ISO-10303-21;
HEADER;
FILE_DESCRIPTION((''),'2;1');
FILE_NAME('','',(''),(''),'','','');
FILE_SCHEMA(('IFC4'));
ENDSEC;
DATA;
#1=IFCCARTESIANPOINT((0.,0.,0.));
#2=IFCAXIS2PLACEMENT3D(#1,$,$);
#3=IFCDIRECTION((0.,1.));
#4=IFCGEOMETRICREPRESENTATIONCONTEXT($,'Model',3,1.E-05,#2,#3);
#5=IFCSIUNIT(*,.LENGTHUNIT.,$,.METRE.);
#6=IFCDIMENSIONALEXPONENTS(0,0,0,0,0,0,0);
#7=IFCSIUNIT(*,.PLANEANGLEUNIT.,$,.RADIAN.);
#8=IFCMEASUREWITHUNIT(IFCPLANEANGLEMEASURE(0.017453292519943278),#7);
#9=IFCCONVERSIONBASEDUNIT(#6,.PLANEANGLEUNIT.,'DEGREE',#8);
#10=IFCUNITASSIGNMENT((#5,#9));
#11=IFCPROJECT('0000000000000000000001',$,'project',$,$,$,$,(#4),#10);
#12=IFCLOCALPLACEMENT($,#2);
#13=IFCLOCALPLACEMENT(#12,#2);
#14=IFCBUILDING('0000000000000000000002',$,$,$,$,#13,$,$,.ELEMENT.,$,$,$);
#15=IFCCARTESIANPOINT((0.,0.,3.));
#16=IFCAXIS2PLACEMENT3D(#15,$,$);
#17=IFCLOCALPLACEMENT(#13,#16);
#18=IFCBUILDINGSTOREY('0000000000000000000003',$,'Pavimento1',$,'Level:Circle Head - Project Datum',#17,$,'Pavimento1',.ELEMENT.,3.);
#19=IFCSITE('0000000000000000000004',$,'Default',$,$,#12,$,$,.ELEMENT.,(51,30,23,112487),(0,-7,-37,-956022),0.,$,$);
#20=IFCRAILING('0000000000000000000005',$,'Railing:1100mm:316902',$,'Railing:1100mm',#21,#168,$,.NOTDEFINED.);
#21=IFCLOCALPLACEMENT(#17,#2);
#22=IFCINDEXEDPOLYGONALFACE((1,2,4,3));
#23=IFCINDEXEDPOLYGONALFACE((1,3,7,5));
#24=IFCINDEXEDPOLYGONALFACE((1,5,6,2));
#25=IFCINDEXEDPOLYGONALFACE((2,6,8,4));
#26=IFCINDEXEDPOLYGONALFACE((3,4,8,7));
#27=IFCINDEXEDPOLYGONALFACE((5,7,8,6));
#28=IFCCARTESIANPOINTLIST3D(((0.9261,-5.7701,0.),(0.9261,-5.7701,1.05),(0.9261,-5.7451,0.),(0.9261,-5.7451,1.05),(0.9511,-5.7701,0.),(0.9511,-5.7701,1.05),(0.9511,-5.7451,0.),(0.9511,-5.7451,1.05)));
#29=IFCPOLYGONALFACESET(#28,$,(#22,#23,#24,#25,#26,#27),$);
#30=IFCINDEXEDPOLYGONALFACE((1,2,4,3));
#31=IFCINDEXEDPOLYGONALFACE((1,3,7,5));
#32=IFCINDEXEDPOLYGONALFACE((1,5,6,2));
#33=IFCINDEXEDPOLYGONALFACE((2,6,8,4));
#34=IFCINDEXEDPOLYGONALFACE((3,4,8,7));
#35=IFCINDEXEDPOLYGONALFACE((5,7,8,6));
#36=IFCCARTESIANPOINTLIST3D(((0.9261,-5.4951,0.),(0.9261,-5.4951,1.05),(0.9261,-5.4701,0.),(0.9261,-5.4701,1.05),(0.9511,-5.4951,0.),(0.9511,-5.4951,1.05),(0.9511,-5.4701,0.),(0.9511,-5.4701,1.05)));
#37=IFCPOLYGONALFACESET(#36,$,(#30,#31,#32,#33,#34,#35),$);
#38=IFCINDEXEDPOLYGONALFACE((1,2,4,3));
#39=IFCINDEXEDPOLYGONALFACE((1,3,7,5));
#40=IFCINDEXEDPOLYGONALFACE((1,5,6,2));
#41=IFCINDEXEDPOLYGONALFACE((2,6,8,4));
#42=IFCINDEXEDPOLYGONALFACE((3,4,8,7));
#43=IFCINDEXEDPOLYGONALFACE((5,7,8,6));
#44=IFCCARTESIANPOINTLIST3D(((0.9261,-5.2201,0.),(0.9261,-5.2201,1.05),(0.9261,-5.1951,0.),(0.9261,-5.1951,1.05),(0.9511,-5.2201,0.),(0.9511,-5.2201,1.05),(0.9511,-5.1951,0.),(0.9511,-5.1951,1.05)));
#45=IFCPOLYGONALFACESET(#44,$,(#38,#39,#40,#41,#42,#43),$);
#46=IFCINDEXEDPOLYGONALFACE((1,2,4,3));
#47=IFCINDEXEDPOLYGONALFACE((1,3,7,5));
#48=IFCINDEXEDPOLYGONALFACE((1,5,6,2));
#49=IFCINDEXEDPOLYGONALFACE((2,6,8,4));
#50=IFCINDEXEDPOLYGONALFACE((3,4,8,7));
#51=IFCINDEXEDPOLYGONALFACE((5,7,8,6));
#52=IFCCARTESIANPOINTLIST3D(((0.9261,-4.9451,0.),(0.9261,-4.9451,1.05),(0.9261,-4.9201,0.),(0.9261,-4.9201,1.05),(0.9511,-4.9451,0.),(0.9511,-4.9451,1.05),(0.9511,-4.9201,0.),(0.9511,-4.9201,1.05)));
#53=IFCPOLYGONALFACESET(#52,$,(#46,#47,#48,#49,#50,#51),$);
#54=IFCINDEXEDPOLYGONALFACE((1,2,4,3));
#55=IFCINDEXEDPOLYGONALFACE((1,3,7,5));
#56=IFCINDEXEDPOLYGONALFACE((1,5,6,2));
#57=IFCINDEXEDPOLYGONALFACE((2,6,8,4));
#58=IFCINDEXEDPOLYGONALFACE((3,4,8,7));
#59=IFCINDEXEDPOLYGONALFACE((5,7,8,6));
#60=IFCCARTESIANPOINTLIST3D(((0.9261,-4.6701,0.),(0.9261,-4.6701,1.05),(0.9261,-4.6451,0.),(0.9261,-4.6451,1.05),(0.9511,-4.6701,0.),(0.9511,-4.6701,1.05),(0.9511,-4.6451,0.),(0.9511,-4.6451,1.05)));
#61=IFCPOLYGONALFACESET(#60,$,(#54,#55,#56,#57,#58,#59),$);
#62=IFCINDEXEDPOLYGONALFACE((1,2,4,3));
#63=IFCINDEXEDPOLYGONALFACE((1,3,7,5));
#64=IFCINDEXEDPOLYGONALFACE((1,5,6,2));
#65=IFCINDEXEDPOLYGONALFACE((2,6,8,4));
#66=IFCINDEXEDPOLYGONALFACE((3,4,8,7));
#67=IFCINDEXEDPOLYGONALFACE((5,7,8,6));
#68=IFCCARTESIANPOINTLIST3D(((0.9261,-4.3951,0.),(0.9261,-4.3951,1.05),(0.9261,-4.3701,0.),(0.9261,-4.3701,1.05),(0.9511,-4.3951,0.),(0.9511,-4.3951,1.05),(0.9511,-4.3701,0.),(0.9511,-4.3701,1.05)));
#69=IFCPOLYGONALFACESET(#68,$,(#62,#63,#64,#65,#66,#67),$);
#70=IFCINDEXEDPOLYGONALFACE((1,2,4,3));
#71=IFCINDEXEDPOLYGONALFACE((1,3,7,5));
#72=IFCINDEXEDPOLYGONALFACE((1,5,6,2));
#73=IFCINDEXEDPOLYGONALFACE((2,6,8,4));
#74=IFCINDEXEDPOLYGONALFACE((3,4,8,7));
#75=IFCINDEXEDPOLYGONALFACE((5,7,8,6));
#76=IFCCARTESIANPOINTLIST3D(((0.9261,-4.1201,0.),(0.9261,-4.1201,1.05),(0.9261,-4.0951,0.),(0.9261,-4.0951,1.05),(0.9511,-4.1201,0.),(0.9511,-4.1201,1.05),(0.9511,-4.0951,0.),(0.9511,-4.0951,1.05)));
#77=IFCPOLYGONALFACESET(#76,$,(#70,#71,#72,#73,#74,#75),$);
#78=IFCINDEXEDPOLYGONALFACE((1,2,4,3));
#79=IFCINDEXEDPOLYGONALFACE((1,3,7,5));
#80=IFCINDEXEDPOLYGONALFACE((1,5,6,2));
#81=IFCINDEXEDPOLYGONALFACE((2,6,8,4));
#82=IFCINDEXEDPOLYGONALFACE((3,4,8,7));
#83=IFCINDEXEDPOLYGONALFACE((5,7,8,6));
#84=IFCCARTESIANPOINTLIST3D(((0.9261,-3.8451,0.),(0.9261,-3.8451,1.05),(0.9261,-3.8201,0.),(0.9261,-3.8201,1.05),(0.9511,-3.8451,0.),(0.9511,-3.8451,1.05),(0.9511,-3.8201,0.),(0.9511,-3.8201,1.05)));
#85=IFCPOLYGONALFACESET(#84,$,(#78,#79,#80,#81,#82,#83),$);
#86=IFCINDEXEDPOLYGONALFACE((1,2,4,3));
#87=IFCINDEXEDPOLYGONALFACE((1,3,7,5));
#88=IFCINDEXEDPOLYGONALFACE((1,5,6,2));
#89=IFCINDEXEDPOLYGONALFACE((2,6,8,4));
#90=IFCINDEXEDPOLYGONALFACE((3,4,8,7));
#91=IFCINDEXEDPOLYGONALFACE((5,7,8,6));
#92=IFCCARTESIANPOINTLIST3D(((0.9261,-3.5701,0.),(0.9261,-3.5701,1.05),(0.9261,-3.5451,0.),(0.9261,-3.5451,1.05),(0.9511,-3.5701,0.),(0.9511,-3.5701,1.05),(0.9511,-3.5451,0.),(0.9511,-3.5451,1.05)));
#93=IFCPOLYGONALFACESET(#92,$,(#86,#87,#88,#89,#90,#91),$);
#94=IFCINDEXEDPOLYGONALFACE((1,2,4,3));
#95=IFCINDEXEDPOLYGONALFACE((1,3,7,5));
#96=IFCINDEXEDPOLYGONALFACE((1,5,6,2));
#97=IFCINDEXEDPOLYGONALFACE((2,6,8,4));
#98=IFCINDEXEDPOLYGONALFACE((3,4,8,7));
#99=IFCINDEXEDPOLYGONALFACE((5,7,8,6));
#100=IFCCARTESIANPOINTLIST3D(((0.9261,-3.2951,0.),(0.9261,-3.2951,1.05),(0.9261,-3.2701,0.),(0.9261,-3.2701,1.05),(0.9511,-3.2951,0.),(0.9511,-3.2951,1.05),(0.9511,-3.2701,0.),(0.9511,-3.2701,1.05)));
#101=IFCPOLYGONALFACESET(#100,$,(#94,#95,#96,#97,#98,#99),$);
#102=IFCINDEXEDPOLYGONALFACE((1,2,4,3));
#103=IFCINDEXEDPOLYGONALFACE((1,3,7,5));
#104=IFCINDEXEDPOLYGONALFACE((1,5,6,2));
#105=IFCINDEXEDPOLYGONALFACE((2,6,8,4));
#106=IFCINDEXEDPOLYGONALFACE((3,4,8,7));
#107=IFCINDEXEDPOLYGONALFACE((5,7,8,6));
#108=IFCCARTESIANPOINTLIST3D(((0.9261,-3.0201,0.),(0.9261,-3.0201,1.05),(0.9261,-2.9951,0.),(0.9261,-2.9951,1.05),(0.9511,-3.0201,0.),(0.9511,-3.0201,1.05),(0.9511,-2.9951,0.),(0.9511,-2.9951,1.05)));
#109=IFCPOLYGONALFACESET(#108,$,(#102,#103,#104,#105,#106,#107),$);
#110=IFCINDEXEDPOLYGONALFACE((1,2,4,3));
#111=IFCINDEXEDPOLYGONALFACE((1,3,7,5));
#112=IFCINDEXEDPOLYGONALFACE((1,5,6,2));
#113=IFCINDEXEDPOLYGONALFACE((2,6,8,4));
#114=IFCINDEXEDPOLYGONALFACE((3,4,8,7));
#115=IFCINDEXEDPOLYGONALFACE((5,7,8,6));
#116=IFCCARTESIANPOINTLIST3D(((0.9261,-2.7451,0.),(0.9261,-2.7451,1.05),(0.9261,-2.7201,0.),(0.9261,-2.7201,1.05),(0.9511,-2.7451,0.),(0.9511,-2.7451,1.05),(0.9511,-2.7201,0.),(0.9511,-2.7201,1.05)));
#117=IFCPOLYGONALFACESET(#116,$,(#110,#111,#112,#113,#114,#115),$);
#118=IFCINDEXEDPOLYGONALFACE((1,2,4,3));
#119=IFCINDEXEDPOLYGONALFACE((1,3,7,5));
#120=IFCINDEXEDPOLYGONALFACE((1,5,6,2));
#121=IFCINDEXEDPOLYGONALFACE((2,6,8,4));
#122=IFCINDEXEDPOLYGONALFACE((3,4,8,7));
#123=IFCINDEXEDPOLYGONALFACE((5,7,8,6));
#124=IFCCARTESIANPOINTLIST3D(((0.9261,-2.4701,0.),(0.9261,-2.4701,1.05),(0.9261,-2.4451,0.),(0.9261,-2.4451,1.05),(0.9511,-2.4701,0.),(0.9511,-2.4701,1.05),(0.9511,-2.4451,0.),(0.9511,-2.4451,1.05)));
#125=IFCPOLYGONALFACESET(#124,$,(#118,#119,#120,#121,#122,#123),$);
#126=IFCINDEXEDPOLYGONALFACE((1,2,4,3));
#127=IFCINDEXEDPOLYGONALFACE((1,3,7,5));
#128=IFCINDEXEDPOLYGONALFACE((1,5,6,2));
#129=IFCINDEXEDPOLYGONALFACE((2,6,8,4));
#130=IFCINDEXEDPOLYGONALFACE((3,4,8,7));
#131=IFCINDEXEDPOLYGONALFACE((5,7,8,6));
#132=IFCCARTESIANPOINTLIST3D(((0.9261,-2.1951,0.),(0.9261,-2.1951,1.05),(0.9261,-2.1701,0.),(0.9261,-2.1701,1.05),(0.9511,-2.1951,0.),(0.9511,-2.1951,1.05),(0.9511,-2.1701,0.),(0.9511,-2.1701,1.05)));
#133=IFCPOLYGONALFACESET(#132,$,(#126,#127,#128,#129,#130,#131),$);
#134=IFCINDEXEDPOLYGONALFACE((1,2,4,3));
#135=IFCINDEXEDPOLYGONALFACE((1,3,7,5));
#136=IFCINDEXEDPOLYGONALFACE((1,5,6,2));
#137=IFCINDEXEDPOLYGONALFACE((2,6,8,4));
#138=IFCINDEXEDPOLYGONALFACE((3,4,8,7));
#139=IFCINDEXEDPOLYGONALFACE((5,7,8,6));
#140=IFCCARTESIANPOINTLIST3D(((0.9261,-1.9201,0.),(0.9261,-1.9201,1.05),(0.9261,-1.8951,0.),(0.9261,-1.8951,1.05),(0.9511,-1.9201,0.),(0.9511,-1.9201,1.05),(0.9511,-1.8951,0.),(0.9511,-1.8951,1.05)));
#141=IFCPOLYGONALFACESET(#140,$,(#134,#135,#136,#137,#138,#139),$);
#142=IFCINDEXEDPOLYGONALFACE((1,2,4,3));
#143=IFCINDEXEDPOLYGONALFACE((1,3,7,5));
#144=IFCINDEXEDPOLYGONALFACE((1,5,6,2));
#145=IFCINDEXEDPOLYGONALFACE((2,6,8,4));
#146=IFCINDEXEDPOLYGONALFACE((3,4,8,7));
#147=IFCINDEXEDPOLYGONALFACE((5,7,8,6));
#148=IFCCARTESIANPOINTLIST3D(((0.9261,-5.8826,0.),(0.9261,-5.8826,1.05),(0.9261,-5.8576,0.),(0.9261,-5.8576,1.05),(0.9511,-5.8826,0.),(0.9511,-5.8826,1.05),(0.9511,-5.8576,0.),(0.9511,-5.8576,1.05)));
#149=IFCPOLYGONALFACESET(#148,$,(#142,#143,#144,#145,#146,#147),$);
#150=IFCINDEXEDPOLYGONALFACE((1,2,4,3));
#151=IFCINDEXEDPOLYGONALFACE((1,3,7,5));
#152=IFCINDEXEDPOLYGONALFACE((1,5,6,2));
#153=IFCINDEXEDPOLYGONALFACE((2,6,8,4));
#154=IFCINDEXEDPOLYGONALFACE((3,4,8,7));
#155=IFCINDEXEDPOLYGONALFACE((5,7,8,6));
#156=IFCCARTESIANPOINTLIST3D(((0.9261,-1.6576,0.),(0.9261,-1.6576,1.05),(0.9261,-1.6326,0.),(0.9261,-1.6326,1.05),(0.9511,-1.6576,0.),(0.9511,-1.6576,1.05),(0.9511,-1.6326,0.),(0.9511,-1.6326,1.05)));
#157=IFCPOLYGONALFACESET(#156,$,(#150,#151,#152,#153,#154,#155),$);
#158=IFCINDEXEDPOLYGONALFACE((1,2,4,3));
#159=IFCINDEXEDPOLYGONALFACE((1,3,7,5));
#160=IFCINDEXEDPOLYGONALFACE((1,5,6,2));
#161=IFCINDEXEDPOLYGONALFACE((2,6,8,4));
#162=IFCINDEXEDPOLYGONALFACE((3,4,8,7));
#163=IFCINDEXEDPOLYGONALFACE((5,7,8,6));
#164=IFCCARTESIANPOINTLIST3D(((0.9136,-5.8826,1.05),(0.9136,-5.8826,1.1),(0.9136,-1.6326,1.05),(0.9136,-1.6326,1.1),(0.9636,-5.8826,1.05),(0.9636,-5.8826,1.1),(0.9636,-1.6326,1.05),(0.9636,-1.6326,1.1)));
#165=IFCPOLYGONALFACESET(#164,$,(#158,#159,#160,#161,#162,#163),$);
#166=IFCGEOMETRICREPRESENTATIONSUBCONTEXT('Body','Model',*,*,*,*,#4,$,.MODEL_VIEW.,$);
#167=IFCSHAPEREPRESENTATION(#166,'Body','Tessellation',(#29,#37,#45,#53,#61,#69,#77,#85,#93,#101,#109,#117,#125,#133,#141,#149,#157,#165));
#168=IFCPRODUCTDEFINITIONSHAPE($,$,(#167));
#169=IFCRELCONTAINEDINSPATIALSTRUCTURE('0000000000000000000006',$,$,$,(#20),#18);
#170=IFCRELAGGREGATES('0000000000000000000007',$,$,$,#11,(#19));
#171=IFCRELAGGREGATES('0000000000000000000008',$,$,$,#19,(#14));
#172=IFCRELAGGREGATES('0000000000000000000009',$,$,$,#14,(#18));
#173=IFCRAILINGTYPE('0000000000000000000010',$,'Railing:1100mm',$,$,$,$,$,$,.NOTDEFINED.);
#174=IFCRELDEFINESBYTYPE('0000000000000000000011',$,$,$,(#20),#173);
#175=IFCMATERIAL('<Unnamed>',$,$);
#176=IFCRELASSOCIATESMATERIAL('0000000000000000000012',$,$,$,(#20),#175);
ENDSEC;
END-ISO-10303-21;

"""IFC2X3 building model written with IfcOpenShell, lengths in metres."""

from ifc_helpers import new_model, entity, si_unit, converted_unit, direction, frame, frame_2d, origin, origin_2d_with_axis, place, context, subcontext, project, spatial, rectangle, extrude, material, type_object, element, save


model = new_model("IFC2X3")

# Units and contexts
model_context = context("Model", 3, precision=1e-05, world=origin(), true_north=direction((0.0, 1.0)))
body_context = subcontext(model_context, "Body", "Model", "MODEL_VIEW")
ifc_project = project(units=[si_unit("LENGTHUNIT", "METRE"), converted_unit("PLANEANGLEUNIT", "DEGREE", entity("IfcPlaneAngleMeasure", 0.017453292519943278), si_unit("PLANEANGLEUNIT", "RADIAN"), dimensions=[0, 0, 0, 0, 0, 0, 0])], contexts=[model_context])

# Site, building, storey
site_placement = place(None, origin())
site = spatial("IfcSite", under=ifc_project, at=site_placement, Name="Default", CompositionType="ELEMENT", RefLatitude=(51, 30, 23, 112487), RefLongitude=(0, -7, -37, -956022), RefElevation=0.0)
building_placement = place(site_placement, origin())
building = spatial("IfcBuilding", under=site, at=building_placement, CompositionType="ELEMENT")
storey_placement = place(building_placement, frame((0.0, 0.0, 3.0)))
storey = spatial("IfcBuildingStorey", under=building, at=storey_placement, Name="Pavimento1", ObjectType="Level:Circle Head - Project Datum", LongName="Pavimento1", CompositionType="ELEMENT", Elevation=3.0)

# Railing
ifc_material_1 = material(Name="<Unnamed>")
railing_type = type_object("IfcRailingType", Name="Railing:1100mm", PredefinedType="NOTDEFINED")
railing_1_placement = place(storey_placement, origin())
element("IfcRailing", 1, at=railing_1_placement, inside=storey, type_object=railing_type, material=ifc_material_1, Name="Railing:1100mm:316902", ObjectType="Railing:1100mm", PredefinedType="NOTDEFINED", context=body_context, shape_type="SweptSolid", body=[
    extrude(rectangle(XDim=0.025, YDim=0.025, at=origin_2d_with_axis()), frame((0.9386, -5.7576, 0.0), z_axis=(0.0, 0.0, 1.0), x_axis=(0.0, -1.0, 0.0)), (0.0, 0.0, 1.0), 1.05),
    extrude(rectangle(XDim=0.025, YDim=0.025, at=origin_2d_with_axis()), frame((0.9386, -5.4826, 0.0), z_axis=(0.0, 0.0, 1.0), x_axis=(0.0, -1.0, 0.0)), (0.0, 0.0, 1.0), 1.05),
    extrude(rectangle(XDim=0.025, YDim=0.025, at=frame_2d((0.0, 0.0), x_axis=(1.0, 0.0))), frame((0.9386, -5.2076, 0.0), z_axis=(0.0, 0.0, 1.0), x_axis=(0.0, -1.0, 0.0)), (0.0, 0.0, 1.0), 1.05),
    extrude(rectangle(XDim=0.025, YDim=0.025, at=origin_2d_with_axis()), frame((0.9386, -4.9326, 0.0), z_axis=(0.0, 0.0, 1.0), x_axis=(0.0, -1.0, 0.0)), (0.0, 0.0, 1.0), 1.05),
    extrude(rectangle(XDim=0.025, YDim=0.025, at=origin_2d_with_axis()), frame((0.9386, -4.6576, 0.0), z_axis=(0.0, 0.0, 1.0), x_axis=(0.0, -1.0, 0.0)), (0.0, 0.0, 1.0), 1.05),
    extrude(rectangle(XDim=0.025, YDim=0.025, at=origin_2d_with_axis()), frame((0.9386, -4.3826, 0.0), z_axis=(0.0, 0.0, 1.0), x_axis=(0.0, -1.0, 0.0)), (0.0, 0.0, 1.0), 1.05),
    extrude(rectangle(XDim=0.025, YDim=0.025, at=origin_2d_with_axis()), frame((0.9386, -4.1076, 0.0), z_axis=(0.0, 0.0, 1.0), x_axis=(0.0, -1.0, 0.0)), (0.0, 0.0, 1.0), 1.05),
    extrude(rectangle(XDim=0.025, YDim=0.025, at=origin_2d_with_axis()), frame((0.9386, -3.8326, 0.0), z_axis=(0.0, 0.0, 1.0), x_axis=(0.0, -1.0, 0.0)), (0.0, 0.0, 1.0), 1.05),
    extrude(rectangle(XDim=0.025, YDim=0.025, at=frame_2d((0.0, 0.0), x_axis=(1.0, 0.0))), frame((0.9386, -3.5576, 0.0), z_axis=(0.0, 0.0, 1.0), x_axis=(0.0, -1.0, 0.0)), (0.0, 0.0, 1.0), 1.05),
    extrude(rectangle(XDim=0.025, YDim=0.025, at=frame_2d((0.0, 0.0), x_axis=(1.0, 0.0))), frame((0.9386, -3.2826, 0.0), z_axis=(0.0, 0.0, 1.0), x_axis=(0.0, -1.0, 0.0)), (0.0, 0.0, 1.0), 1.05),
    extrude(rectangle(XDim=0.025, YDim=0.025, at=origin_2d_with_axis()), frame((0.9386, -3.0076, 0.0), z_axis=(0.0, 0.0, 1.0), x_axis=(0.0, -1.0, 0.0)), (0.0, 0.0, 1.0), 1.05),
    extrude(rectangle(XDim=0.025, YDim=0.025, at=origin_2d_with_axis()), frame((0.9386, -2.7326, 0.0), z_axis=(0.0, 0.0, 1.0), x_axis=(0.0, -1.0, 0.0)), (0.0, 0.0, 1.0), 1.05),
    extrude(rectangle(XDim=0.025, YDim=0.025, at=origin_2d_with_axis()), frame((0.9386, -2.4576, 0.0), z_axis=(0.0, 0.0, 1.0), x_axis=(0.0, -1.0, 0.0)), (0.0, 0.0, 1.0), 1.05),
    extrude(rectangle(XDim=0.025, YDim=0.025, at=frame_2d((0.0, 0.0), x_axis=(1.0, 0.0))), frame((0.9386, -2.1826, 0.0), z_axis=(0.0, 0.0, 1.0), x_axis=(0.0, -1.0, 0.0)), (0.0, 0.0, 1.0), 1.05),
    extrude(rectangle(XDim=0.025, YDim=0.025, at=frame_2d((0.0, 0.0), x_axis=(1.0, 0.0))), frame((0.9386, -1.9076, 0.0), z_axis=(0.0, 0.0, 1.0), x_axis=(0.0, -1.0, 0.0)), (0.0, 0.0, 1.0), 1.05),
    extrude(rectangle(XDim=0.025, YDim=0.025, at=frame_2d((0.0, 0.0), x_axis=(1.0, 0.0))), frame((0.9386, -5.8701, 0.0), z_axis=(0.0, 0.0, 1.0), x_axis=(0.0, -1.0, 0.0)), (0.0, 0.0, 1.0), 1.05),
    extrude(rectangle(XDim=0.025, YDim=0.025, at=origin_2d_with_axis()), frame((0.9386, -1.6451, 0.0), z_axis=(0.0, 0.0, 1.0), x_axis=(0.0, -1.0, 0.0)), (0.0, 0.0, 1.0), 1.05),
    extrude(rectangle(XDim=4.25, YDim=0.05, at=frame_2d((0.0, 0.0), x_axis=(1.0, 0.0))), frame((0.9386, -3.7576, 1.05), z_axis=(0.0, 0.0, 1.0), x_axis=(0.0, -1.0, 0.0)), (0.0, 0.0, 1.0), 0.05),
])

save(model, "model.ifc")
